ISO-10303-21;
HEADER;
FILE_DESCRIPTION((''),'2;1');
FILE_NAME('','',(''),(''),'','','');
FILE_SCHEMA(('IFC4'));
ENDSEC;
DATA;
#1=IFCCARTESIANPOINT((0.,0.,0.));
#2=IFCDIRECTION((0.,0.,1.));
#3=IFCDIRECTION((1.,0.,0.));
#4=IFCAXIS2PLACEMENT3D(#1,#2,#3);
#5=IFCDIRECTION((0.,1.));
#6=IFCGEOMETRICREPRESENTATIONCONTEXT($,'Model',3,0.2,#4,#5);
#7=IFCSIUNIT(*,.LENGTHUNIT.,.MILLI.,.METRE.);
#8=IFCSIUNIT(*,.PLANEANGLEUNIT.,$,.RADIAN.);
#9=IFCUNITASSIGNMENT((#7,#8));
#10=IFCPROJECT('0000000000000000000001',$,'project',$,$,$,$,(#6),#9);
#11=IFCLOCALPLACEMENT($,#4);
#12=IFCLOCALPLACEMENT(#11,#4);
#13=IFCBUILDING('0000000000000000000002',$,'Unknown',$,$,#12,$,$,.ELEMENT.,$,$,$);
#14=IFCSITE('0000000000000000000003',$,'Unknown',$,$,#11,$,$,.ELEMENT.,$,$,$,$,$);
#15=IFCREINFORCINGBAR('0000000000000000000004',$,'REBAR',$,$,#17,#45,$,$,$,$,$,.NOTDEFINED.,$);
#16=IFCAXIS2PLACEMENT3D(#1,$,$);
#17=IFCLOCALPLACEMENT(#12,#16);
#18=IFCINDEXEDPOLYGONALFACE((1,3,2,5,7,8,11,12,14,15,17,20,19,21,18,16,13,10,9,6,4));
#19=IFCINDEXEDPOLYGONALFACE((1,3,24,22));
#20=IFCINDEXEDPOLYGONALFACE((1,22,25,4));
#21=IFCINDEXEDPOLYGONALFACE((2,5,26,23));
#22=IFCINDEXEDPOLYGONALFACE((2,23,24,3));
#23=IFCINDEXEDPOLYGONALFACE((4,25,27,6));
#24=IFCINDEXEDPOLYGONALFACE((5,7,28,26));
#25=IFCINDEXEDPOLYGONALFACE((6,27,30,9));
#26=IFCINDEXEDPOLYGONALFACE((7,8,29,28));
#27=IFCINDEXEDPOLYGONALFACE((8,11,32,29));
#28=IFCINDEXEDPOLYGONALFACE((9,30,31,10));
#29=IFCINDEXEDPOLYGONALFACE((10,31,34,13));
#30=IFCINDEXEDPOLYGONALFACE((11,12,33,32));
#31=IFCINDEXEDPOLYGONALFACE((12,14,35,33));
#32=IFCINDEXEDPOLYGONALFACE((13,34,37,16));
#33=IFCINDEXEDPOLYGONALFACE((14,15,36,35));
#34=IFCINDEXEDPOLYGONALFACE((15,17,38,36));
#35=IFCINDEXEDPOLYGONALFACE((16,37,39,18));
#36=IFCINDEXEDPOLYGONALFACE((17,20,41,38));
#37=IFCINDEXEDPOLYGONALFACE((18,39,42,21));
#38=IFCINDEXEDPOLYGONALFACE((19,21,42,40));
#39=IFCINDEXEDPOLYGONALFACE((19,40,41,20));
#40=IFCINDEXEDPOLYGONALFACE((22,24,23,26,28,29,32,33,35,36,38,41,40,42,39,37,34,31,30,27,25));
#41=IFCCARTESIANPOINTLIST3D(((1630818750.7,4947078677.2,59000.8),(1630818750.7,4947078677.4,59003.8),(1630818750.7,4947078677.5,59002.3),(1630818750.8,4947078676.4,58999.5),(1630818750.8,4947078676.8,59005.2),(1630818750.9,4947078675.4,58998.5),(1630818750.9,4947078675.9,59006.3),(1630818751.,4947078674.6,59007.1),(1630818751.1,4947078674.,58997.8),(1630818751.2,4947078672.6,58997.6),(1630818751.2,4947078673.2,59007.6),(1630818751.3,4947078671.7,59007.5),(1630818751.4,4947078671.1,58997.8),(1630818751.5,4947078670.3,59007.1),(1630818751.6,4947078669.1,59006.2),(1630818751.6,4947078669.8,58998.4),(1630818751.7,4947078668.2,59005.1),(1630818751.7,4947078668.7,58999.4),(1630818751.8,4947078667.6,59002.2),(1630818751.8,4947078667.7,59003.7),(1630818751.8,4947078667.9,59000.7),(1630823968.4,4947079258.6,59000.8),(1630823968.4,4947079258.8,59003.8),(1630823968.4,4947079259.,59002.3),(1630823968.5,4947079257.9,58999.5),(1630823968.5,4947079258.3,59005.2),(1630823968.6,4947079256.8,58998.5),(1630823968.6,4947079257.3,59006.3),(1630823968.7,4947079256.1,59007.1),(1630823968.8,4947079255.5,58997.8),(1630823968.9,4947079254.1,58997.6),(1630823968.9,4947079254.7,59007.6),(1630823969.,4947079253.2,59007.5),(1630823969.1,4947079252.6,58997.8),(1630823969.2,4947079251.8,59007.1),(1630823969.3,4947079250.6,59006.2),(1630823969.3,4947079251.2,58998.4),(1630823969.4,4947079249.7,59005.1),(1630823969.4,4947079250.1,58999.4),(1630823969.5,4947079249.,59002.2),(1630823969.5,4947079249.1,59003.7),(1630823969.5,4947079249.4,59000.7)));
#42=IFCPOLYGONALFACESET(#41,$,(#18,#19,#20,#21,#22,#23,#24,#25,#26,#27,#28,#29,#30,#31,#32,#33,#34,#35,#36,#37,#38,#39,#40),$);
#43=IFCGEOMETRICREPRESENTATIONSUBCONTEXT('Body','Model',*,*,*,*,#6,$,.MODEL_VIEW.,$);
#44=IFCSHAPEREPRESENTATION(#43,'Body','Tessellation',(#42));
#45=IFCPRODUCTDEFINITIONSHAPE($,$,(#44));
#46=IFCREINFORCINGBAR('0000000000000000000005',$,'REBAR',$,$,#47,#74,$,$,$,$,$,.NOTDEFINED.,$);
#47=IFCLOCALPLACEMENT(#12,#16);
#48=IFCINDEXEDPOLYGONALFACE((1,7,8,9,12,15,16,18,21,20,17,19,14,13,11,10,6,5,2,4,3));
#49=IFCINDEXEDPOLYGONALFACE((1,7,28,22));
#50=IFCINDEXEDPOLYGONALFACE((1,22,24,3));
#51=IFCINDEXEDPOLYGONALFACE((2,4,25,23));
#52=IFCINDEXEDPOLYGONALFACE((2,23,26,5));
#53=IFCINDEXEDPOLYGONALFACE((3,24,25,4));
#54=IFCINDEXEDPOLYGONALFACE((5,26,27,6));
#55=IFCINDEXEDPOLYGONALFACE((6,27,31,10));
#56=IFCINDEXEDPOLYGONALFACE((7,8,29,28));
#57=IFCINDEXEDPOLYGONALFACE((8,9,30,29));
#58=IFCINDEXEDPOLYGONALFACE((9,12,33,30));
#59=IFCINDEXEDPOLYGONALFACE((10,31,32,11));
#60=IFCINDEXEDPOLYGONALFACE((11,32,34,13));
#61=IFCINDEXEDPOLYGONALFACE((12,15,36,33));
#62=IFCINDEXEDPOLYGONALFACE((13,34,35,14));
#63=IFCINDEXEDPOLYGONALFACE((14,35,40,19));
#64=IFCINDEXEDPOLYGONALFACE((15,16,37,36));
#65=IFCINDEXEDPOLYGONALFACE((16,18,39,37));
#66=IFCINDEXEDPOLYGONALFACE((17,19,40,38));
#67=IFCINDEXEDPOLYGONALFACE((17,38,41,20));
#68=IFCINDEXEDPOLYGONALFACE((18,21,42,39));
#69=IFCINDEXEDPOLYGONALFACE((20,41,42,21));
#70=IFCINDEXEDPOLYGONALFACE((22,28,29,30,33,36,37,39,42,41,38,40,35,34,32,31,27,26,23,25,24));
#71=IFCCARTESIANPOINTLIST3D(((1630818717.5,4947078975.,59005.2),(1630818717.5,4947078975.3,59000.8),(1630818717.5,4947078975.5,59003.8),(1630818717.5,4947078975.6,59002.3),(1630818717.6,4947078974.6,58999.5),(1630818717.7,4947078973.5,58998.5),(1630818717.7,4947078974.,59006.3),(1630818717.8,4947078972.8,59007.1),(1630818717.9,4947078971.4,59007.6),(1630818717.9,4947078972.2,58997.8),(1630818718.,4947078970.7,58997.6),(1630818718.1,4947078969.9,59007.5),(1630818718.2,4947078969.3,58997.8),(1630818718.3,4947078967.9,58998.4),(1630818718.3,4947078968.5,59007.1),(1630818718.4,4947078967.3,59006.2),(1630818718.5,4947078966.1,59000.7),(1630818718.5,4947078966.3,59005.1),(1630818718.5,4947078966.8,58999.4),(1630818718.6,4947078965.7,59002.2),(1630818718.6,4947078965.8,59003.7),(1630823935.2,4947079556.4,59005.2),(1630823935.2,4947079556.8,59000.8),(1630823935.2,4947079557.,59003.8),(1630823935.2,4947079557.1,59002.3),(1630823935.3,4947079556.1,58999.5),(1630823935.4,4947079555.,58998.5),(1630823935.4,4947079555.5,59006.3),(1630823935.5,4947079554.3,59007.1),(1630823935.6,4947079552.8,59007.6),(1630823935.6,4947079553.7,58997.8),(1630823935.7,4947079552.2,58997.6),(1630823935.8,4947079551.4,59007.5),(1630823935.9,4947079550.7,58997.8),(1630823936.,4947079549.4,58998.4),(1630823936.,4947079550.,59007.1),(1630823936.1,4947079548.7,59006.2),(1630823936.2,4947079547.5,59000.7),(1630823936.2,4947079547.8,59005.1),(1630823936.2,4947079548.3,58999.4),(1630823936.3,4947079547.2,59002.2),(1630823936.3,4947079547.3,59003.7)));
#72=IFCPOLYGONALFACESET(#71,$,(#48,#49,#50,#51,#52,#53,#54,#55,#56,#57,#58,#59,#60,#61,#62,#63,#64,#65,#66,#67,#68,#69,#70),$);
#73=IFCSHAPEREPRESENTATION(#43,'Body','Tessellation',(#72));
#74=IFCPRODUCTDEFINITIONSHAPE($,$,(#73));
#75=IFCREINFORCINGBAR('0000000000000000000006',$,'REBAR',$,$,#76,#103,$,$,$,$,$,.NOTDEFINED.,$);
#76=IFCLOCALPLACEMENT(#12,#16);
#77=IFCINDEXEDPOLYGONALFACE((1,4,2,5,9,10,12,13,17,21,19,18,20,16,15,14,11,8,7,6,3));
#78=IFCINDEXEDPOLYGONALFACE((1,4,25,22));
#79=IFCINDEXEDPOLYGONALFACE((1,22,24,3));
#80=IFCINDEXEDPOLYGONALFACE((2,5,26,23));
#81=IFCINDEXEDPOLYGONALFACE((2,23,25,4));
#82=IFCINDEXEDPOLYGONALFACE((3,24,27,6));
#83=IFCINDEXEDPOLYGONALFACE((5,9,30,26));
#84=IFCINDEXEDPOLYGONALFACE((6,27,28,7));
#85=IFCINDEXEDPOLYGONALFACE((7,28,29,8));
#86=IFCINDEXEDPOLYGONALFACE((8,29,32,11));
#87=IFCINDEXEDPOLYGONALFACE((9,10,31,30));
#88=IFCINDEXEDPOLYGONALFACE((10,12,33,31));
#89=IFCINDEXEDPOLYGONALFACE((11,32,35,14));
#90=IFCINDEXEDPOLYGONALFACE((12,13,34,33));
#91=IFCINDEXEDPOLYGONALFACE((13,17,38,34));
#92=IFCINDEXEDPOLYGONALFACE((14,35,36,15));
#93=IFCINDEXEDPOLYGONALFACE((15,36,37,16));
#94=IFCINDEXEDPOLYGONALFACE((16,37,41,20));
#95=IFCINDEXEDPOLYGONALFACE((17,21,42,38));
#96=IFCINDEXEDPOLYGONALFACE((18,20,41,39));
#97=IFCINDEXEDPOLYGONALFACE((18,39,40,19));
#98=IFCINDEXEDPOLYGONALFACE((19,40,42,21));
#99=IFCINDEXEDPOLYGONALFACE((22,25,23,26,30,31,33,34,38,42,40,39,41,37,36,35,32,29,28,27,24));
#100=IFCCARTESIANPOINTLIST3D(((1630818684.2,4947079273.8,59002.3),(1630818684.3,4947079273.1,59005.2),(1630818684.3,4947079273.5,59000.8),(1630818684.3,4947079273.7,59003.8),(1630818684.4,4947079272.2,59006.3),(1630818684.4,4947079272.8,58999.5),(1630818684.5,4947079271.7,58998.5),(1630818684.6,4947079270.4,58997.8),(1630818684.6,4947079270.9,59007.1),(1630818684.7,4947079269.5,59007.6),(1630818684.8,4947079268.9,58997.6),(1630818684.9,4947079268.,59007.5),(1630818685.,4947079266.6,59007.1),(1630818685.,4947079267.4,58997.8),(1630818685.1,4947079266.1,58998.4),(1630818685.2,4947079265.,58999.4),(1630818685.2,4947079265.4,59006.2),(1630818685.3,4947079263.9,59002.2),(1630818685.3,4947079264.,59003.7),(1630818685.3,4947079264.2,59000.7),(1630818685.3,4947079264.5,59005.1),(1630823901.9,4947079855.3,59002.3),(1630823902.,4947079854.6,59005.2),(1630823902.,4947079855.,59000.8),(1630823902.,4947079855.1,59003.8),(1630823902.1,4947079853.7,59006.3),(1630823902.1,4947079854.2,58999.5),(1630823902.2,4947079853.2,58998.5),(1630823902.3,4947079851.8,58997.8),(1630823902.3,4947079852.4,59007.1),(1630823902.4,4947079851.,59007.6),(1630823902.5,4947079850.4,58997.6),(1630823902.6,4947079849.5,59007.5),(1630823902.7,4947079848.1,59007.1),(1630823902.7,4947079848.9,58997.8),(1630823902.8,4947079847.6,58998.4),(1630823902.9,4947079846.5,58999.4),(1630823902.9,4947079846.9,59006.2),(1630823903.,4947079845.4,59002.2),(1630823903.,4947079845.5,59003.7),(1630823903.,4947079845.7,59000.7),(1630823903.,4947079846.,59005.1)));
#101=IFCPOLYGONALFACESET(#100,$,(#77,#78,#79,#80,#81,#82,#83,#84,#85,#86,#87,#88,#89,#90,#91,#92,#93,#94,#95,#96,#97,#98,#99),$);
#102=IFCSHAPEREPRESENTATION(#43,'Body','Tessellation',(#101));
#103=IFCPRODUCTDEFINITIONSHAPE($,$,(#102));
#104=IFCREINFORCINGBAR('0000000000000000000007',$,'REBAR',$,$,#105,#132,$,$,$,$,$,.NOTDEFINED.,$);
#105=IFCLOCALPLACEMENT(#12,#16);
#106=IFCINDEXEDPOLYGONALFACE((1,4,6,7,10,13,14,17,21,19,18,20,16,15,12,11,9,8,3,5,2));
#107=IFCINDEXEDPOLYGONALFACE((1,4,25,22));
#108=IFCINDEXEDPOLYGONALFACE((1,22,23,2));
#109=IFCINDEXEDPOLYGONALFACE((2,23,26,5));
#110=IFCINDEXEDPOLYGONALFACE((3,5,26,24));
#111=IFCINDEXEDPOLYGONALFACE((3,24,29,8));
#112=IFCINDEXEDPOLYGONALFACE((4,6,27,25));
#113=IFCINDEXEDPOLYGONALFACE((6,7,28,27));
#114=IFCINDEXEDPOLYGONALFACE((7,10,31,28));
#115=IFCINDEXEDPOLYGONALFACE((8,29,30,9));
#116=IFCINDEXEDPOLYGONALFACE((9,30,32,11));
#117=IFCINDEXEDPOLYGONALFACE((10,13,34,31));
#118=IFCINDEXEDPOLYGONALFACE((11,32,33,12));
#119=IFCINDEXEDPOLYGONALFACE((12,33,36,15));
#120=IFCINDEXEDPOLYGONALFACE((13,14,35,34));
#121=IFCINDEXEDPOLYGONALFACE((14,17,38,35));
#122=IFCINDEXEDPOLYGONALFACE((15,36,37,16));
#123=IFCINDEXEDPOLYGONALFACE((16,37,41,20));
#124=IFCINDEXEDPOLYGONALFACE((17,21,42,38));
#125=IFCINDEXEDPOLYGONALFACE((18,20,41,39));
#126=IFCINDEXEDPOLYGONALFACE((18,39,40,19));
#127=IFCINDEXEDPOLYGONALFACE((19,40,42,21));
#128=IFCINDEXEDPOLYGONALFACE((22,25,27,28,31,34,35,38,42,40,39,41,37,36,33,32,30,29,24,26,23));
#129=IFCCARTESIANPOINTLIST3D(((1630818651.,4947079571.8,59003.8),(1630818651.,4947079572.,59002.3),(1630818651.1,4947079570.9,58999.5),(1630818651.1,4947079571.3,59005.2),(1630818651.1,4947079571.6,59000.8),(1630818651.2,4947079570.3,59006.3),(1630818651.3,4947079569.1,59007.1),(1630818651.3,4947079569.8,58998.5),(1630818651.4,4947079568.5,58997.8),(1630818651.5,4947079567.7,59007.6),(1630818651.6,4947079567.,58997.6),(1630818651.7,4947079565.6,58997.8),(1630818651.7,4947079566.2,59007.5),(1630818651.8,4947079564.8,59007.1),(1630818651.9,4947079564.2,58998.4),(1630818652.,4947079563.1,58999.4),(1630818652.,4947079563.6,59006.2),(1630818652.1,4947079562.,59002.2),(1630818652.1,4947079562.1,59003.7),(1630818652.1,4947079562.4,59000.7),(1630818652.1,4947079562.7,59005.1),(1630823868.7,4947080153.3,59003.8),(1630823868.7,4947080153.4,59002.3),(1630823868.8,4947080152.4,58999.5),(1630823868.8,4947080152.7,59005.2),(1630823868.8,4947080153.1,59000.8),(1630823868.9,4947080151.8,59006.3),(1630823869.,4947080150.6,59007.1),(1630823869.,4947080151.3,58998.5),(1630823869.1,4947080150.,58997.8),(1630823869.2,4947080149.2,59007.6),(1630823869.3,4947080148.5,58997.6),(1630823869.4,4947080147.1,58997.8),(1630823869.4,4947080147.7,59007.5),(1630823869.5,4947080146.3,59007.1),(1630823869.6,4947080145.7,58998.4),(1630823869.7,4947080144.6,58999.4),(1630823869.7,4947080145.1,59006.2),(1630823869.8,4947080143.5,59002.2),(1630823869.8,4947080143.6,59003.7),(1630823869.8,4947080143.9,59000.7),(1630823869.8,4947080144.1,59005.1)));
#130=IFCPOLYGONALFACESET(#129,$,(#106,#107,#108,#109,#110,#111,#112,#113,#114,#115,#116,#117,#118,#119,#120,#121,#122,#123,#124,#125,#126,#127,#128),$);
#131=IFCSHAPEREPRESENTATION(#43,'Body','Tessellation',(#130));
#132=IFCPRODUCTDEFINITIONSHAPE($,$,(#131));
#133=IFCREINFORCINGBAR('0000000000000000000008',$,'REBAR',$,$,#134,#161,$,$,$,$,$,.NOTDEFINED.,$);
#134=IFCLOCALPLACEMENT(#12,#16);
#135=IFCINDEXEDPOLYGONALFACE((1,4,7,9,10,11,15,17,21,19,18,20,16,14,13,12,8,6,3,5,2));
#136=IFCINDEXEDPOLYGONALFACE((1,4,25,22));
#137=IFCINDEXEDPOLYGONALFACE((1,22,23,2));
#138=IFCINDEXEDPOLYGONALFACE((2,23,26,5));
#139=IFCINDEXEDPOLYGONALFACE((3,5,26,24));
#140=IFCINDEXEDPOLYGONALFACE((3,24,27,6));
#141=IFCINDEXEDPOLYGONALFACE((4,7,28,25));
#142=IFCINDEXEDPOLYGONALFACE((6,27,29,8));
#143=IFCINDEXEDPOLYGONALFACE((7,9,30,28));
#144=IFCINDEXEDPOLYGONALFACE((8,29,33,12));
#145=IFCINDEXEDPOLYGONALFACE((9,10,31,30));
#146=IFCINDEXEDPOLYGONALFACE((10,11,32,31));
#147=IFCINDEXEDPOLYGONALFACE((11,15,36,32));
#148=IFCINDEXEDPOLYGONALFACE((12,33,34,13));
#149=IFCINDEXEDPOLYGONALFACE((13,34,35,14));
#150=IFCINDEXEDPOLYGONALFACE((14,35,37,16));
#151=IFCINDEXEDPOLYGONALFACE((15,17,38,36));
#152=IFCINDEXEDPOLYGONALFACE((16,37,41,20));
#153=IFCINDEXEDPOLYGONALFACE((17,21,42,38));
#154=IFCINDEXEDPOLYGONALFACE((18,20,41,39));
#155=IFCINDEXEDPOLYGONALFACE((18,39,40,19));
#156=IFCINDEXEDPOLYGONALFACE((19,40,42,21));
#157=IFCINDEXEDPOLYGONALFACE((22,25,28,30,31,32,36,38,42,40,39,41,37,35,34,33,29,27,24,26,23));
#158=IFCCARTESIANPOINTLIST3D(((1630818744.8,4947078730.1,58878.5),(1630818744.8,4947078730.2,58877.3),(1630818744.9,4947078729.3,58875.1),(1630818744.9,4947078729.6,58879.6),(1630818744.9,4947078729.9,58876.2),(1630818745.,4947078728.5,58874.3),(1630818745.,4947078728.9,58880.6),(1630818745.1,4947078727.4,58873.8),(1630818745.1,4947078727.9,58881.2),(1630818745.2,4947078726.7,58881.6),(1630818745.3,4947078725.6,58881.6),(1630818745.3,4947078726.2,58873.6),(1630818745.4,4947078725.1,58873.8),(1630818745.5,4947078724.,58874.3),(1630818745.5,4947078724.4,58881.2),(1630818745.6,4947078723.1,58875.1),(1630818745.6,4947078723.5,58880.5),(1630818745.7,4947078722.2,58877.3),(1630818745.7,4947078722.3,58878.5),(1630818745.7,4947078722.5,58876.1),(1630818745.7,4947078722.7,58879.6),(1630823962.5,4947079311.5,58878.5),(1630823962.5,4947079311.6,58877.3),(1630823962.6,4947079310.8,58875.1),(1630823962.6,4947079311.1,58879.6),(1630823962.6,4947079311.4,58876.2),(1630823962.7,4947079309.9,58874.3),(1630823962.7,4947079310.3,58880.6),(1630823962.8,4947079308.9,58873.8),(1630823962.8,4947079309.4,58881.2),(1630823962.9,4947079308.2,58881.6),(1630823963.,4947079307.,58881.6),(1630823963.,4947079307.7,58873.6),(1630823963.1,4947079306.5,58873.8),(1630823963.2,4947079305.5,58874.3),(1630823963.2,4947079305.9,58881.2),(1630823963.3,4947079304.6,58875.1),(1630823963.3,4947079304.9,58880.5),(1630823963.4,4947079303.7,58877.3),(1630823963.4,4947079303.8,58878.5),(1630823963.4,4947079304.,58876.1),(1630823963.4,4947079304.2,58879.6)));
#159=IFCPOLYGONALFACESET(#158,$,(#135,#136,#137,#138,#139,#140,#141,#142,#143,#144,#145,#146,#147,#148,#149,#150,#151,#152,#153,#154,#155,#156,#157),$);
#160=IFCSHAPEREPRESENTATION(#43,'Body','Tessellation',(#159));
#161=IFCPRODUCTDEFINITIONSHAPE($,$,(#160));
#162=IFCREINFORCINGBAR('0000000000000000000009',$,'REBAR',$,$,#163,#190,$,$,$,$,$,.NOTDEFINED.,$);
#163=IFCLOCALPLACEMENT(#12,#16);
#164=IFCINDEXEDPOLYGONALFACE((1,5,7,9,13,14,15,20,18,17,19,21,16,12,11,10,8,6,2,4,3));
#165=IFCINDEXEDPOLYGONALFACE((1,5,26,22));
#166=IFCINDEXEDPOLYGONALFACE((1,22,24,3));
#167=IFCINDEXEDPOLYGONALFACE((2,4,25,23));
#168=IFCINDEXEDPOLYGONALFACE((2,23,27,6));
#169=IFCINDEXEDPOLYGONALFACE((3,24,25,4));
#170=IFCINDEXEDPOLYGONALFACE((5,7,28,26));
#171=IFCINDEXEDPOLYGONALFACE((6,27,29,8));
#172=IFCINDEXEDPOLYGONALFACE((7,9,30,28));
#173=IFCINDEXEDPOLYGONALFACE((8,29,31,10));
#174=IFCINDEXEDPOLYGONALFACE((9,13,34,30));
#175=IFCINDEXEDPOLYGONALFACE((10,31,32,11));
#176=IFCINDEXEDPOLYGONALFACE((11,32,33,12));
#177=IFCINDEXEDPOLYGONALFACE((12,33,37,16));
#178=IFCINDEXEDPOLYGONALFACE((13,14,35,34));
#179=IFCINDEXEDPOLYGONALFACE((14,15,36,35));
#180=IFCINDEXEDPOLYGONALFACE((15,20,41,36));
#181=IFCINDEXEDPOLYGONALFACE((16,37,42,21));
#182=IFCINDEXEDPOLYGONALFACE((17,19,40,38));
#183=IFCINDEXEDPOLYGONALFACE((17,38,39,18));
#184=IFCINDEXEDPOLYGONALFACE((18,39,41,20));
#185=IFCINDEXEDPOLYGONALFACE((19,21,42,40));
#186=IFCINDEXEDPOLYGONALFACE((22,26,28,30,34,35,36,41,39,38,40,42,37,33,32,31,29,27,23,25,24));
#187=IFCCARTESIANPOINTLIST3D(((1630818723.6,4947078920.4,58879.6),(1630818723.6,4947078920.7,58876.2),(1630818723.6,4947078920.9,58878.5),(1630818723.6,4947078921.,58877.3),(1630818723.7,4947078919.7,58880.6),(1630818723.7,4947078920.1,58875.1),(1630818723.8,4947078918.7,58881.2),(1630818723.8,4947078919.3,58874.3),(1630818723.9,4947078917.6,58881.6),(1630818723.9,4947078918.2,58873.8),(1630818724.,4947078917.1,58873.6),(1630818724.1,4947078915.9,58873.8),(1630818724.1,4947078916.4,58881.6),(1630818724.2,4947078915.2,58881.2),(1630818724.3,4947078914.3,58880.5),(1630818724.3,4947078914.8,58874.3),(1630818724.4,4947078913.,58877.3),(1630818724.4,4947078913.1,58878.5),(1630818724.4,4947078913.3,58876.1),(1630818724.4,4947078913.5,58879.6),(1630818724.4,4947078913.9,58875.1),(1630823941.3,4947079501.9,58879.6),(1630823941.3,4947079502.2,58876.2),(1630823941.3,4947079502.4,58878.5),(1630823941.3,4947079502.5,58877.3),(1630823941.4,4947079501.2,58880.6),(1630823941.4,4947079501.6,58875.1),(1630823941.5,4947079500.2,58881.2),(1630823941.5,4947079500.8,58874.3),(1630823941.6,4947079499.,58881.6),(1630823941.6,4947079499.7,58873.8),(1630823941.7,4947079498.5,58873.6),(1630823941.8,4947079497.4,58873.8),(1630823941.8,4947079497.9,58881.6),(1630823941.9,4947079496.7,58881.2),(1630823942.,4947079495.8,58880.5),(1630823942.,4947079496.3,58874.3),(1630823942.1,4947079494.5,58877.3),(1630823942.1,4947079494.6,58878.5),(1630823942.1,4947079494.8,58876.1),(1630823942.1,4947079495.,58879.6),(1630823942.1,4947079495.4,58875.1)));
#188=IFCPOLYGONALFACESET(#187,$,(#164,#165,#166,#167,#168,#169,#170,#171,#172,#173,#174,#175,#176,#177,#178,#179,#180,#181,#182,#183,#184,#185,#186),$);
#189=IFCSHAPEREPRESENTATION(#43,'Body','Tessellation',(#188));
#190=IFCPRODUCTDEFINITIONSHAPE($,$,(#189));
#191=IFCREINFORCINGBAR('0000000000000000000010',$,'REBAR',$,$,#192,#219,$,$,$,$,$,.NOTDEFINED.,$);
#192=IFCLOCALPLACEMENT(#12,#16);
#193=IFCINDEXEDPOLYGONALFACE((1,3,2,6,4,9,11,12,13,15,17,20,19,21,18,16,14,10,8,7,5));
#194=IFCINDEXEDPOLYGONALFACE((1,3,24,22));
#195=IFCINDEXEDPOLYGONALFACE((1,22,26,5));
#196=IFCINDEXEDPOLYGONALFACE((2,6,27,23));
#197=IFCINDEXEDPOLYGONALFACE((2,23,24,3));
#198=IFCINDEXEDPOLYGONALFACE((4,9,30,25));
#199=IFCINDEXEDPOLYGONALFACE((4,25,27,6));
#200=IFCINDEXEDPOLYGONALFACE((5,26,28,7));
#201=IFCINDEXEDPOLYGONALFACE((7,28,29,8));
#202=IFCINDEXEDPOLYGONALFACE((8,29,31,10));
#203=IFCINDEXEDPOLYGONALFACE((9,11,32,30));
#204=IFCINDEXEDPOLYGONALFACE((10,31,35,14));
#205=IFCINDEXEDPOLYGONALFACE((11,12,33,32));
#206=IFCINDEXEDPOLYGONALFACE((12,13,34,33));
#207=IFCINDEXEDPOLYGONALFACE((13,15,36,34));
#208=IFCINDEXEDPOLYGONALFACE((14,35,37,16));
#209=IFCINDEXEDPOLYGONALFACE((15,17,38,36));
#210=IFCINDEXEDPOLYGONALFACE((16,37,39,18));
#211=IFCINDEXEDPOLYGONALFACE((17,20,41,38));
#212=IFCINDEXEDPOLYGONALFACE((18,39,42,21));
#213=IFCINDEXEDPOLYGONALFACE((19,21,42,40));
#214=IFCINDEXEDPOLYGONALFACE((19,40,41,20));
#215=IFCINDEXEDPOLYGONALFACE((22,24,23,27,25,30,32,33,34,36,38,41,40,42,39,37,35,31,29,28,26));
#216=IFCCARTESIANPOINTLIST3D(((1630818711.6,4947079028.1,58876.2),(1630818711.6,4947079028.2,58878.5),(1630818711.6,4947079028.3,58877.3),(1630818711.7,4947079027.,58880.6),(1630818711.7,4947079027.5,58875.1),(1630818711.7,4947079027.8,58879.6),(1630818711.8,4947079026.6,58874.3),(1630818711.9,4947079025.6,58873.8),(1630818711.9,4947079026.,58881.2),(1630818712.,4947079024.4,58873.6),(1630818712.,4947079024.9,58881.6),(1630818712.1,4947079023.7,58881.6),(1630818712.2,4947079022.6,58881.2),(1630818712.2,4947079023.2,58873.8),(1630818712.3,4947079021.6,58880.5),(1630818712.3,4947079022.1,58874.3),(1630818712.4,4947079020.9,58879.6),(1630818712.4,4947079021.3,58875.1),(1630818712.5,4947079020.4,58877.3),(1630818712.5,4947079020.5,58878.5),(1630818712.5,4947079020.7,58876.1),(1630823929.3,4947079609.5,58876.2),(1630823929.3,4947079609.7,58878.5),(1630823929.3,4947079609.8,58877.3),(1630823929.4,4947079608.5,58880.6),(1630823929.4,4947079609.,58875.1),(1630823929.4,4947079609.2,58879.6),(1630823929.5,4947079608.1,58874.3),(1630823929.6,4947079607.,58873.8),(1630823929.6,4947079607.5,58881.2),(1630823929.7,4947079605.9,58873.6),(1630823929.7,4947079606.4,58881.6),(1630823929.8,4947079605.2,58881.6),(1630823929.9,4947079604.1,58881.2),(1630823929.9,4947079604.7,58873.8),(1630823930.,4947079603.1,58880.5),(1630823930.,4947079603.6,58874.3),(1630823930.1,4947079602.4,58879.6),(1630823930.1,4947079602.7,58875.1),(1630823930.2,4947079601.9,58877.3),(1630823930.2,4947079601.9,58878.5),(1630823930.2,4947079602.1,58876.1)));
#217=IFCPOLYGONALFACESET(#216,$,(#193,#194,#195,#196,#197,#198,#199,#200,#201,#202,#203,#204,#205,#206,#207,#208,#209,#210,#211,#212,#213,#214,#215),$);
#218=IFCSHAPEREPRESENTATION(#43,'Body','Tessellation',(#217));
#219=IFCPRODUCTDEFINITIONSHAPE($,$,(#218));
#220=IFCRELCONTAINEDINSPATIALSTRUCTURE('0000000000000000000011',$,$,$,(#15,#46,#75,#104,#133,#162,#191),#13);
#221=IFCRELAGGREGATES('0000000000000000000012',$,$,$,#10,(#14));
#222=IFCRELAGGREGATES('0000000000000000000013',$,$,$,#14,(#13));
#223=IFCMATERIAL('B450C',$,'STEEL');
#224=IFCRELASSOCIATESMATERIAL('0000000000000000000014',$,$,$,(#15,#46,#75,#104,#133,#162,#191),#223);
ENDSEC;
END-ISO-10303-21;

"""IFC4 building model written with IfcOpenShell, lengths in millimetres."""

from ifc_helpers import new_model, entity, si_unit, direction, frame, origin_with_axes, place, context, subcontext, project, spatial, material, element, save


model = new_model("IFC4")

# Units and contexts
model_context = context("Model", 3, precision=0.2, world=origin_with_axes(), true_north=direction((0.0, 1.0)))
body_context = subcontext(model_context, "Body", "Model", "MODEL_VIEW")
ifc_project = project(units=[si_unit("LENGTHUNIT", "METRE", prefix="MILLI"), si_unit("PLANEANGLEUNIT", "RADIAN")], contexts=[model_context])

# Site, building
site_placement = place(None, origin_with_axes())
site = spatial("IfcSite", under=ifc_project, at=site_placement, Name="Unknown", CompositionType="ELEMENT")
building_placement = place(site_placement, origin_with_axes())
building = spatial("IfcBuilding", under=site, at=building_placement, Name="Unknown", CompositionType="ELEMENT")

# Reinforcing bars
ifc_material = material(Name="B450C", Category="STEEL")
for number, where, z_axis, x_axis, name in (
    (1, (1630818751.3, 4947078672.5, 59002.6), (-0.007106, 0.063762, 0.99794), (0.993847, 0.110757, 0.0), "REBAR"),
    (2, (1630818718.0, 4947078970.7, 59002.6), (-0.007106, 0.063762, 0.99794), (0.993847, 0.110757, 0.0), "REBAR"),
    (3, (1630818684.8, 4947079268.8, 59002.6), (-0.007106, 0.063762, 0.99794), (0.993847, 0.110757, 0.0), "REBAR"),
    (4, (1630818651.6, 4947079567.0, 59002.6), (-0.007106, 0.063762, 0.99794), (0.993847, 0.110757, 0.0), "REBAR"),
):
    element("IfcReinforcingBar", number, at=place(building_placement, frame(where, z_axis=z_axis, x_axis=x_axis)), inside=building, material=ifc_material, Name=name, PredefinedType="NOTDEFINED", context=body_context, shape_type="AdvancedSweptSolid", body=[
        entity("IfcSweptDiskSolid", entity("IfcIndexedPolyCurve", entity("IfcCartesianPointList3D", [[0.0, 0.0, 0.0], [5250.0, 0.0, 0.0]]), [entity("IfcLineIndex", [1, 2])]), 5.0),
    ])
for number, where, z_axis, x_axis, name in (
    (5, (1630818745.3, 4947078726.2, 58877.6), (-0.007106, 0.063762, 0.99794), (0.993847, 0.110757, 0.0), "REBAR"),
    (6, (1630818724.0, 4947078917.0, 58877.6), (-0.007106, 0.063762, 0.99794), (0.993847, 0.110757, 0.0), "REBAR"),
    (7, (1630818712.0, 4947079024.3, 58877.6), (-0.007106, 0.063762, 0.99794), (0.993847, 0.110757, 0.0), "REBAR"),
):
    element("IfcReinforcingBar", number, at=place(building_placement, frame(where, z_axis=z_axis, x_axis=x_axis)), inside=building, material=ifc_material, Name=name, PredefinedType="NOTDEFINED", context=body_context, shape_type="AdvancedSweptSolid", body=[
        entity("IfcSweptDiskSolid", entity("IfcIndexedPolyCurve", entity("IfcCartesianPointList3D", [[0.0, 0.0, 0.0], [5250.0, 0.0, 0.0]]), [entity("IfcLineIndex", [1, 2])]), 4.0),
    ])

save(model, "model.ifc")
